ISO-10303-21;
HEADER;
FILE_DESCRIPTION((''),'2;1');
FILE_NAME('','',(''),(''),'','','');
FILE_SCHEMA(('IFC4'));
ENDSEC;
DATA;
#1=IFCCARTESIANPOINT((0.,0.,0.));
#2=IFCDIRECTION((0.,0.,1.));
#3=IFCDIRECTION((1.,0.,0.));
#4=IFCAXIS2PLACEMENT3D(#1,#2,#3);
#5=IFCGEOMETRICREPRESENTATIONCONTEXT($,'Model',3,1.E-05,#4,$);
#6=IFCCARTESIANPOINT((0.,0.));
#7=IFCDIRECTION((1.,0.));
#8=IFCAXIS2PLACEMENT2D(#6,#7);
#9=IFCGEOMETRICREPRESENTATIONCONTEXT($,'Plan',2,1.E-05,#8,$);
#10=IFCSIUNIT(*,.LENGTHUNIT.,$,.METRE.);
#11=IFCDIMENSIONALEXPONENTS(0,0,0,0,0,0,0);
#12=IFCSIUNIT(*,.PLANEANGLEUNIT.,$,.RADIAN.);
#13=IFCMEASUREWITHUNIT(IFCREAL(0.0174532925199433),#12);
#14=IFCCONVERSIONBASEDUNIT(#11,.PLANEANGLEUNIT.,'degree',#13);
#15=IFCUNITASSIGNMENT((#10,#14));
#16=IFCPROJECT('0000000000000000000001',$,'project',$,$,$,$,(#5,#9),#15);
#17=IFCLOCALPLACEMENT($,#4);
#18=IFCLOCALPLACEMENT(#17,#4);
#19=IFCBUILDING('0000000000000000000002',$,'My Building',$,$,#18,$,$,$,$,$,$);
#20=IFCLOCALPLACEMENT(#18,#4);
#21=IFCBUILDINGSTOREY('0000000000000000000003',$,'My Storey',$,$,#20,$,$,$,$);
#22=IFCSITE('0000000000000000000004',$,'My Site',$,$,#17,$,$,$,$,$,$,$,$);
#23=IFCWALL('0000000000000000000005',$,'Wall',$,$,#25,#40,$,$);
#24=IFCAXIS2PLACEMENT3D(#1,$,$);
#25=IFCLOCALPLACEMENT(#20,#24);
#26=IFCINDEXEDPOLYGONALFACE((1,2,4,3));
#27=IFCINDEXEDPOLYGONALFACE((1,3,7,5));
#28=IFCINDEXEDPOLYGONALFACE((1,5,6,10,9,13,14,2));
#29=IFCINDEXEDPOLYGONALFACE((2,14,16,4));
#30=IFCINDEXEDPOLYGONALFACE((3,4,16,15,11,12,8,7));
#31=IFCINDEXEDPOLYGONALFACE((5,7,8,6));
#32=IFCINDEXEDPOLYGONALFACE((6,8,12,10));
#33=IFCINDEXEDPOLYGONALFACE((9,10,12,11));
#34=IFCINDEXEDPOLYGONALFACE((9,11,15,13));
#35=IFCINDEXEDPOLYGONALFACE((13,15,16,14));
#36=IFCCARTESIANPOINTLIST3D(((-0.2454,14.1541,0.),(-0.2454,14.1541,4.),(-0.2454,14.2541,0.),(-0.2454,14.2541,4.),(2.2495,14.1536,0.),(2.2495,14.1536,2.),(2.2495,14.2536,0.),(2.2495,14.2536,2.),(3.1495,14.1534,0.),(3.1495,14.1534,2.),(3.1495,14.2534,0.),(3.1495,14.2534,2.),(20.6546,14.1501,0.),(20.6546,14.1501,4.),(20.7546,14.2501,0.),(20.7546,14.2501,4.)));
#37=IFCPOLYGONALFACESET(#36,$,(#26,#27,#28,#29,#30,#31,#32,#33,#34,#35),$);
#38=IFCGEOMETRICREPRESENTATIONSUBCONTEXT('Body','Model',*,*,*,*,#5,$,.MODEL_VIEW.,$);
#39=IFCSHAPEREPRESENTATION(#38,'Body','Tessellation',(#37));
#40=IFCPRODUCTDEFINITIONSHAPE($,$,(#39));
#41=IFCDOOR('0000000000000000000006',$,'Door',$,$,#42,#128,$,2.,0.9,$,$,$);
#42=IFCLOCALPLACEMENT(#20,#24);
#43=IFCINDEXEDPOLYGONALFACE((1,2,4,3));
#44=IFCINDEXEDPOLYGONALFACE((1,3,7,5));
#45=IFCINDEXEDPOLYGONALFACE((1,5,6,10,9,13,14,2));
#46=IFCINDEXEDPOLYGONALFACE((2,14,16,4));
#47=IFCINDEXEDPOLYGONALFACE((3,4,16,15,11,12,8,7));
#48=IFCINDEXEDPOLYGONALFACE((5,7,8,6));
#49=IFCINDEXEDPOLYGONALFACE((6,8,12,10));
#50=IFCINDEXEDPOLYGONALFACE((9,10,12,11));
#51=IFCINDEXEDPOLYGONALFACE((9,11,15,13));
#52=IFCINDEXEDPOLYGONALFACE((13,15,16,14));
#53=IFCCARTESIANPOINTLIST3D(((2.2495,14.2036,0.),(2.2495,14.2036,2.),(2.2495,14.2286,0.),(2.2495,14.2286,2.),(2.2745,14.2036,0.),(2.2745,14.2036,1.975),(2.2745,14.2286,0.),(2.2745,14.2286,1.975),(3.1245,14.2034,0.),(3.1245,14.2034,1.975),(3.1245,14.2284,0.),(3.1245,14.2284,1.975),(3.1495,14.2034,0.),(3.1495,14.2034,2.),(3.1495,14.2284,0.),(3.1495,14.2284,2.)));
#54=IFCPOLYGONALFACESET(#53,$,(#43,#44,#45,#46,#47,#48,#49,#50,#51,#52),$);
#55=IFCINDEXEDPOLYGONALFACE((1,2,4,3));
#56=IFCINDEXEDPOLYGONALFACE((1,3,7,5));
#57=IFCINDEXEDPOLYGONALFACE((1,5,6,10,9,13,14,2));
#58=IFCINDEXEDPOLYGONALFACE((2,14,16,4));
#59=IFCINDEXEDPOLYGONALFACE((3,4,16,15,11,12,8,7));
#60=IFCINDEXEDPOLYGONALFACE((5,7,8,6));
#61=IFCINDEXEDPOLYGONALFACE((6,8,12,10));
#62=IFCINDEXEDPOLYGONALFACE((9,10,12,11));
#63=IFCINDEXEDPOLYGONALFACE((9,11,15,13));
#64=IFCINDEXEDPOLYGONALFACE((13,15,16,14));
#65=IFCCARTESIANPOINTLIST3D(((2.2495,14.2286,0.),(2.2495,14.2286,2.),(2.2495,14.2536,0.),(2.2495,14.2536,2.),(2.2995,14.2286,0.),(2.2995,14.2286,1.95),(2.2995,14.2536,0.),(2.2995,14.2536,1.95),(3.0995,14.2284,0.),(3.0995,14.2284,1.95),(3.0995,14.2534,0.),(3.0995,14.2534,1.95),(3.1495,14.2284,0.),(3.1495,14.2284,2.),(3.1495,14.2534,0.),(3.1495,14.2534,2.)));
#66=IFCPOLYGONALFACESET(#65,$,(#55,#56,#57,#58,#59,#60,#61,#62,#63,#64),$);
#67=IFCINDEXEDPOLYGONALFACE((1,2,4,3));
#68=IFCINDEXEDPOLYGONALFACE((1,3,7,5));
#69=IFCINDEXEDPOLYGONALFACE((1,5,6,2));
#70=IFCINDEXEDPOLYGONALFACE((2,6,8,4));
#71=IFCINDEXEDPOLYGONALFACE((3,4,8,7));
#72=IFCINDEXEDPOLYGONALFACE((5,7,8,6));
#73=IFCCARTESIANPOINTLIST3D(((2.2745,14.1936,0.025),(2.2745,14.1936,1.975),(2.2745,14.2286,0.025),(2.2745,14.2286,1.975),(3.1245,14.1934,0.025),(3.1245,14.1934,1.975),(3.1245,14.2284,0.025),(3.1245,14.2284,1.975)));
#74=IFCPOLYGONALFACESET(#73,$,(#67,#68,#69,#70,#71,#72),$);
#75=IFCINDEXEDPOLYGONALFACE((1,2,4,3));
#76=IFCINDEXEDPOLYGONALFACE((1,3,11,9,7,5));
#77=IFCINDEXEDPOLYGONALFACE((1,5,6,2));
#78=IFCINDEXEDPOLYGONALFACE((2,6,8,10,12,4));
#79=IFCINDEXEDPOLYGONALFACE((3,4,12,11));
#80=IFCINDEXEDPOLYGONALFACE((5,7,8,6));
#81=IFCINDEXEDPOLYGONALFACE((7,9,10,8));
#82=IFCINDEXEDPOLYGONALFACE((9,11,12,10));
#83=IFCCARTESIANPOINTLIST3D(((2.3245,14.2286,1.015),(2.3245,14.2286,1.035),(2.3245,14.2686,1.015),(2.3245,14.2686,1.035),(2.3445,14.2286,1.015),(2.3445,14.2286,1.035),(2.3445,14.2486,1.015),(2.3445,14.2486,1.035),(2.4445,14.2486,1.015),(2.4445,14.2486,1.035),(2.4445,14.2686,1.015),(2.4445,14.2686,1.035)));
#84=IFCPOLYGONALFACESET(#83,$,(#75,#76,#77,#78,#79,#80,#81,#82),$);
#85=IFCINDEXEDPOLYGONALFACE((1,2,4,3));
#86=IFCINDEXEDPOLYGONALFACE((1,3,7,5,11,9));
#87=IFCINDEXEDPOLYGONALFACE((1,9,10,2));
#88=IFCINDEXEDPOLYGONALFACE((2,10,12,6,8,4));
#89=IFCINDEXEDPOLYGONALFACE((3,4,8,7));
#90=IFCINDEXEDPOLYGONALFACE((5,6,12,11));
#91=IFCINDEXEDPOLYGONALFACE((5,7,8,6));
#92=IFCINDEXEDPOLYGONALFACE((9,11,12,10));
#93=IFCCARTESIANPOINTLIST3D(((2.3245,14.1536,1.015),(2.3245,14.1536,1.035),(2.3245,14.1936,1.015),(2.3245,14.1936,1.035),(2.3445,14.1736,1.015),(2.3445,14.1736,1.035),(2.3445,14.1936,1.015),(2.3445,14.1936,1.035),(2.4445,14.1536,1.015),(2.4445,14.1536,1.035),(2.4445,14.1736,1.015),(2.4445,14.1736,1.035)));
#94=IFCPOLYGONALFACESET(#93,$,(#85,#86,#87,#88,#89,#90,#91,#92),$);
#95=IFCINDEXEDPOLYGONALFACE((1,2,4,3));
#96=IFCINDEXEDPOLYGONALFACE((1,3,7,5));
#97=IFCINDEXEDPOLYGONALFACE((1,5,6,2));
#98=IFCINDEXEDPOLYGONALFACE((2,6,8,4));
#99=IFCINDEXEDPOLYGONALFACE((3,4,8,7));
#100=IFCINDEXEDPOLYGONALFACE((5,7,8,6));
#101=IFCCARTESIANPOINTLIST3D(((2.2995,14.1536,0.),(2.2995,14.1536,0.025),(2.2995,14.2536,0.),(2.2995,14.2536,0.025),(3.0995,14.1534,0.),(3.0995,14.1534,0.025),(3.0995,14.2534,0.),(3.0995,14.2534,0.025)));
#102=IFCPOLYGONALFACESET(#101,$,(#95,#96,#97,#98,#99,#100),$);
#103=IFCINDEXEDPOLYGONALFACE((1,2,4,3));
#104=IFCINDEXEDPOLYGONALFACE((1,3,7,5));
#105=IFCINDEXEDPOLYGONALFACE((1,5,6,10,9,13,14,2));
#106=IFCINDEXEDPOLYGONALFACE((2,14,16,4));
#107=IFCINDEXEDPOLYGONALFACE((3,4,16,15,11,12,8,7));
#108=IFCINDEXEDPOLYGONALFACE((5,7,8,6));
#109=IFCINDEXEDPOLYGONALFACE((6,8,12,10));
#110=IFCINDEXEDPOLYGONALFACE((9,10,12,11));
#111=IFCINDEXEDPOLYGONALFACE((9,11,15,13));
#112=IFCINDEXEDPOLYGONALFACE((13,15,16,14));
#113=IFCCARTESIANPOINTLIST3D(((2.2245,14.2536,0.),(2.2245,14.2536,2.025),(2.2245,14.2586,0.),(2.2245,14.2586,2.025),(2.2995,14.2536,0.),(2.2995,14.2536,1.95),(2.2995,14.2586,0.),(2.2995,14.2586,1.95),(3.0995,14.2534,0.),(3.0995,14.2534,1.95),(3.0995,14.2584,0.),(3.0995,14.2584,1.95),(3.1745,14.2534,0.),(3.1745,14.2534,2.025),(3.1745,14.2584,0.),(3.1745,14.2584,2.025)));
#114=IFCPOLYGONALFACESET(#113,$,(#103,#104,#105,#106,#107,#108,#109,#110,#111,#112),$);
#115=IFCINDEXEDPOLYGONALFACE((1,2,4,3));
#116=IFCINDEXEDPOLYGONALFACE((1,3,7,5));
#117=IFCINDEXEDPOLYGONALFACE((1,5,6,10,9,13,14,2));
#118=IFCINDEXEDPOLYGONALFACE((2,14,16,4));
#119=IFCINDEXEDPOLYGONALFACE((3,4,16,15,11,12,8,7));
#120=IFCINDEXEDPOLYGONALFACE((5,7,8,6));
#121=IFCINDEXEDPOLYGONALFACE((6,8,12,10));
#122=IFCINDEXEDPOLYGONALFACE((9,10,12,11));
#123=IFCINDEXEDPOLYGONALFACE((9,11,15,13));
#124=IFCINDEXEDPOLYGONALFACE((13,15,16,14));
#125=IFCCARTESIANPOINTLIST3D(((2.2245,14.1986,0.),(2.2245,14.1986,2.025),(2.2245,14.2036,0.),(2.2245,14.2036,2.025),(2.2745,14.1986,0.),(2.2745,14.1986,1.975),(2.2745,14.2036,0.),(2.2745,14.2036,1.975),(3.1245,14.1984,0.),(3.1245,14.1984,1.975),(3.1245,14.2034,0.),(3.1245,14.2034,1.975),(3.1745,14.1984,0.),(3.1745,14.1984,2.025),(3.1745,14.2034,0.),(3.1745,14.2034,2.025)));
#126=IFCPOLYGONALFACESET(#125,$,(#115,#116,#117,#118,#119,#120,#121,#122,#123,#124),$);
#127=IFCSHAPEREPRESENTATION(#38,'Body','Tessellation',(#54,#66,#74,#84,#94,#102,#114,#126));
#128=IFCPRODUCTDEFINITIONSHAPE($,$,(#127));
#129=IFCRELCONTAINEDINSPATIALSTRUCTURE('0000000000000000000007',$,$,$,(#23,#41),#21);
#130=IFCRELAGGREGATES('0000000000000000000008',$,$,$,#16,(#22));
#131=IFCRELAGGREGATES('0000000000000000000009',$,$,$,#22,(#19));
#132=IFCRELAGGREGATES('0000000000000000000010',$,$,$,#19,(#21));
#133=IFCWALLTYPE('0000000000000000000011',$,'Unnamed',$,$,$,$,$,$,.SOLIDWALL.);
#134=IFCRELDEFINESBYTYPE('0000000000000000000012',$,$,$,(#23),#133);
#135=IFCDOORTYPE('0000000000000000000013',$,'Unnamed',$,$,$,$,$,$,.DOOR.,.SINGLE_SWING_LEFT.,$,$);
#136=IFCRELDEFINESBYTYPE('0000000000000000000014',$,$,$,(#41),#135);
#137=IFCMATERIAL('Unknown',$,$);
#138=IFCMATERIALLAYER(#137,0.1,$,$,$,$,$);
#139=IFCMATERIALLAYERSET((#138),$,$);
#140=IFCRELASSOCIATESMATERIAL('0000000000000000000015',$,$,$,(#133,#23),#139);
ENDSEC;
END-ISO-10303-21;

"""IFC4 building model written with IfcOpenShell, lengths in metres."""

from ifc_helpers import new_model, entity, si_unit, converted_unit, frame, origin_with_axes, origin_2d_with_axis, place, context, subcontext, project, spatial, line, indexed_curve, outline, extrude, shape, source, transform, mapped, material, layer, layer_set, layer_usage, type_object, type_shapes, element, fill, save


model = new_model("IFC4")

# Units and contexts
model_context = context("Model", 3, precision=1e-05, world=origin_with_axes())
plan_context = context("Plan", 2, precision=1e-05, world=origin_2d_with_axis())
body_context_1 = subcontext(model_context, "Body", "Model", "MODEL_VIEW")
body_context_2 = subcontext(plan_context, "Body", "Plan", "PLAN_VIEW")
ifc_project = project(units=[si_unit("LENGTHUNIT", "METRE"), converted_unit("PLANEANGLEUNIT", "degree", entity("IfcReal", 0.0174532925199433), si_unit("PLANEANGLEUNIT", "RADIAN"), dimensions=[0, 0, 0, 0, 0, 0, 0])], contexts=[model_context, plan_context])

# Site, building, storey
site_placement = place(None, origin_with_axes())
site = spatial("IfcSite", under=ifc_project, at=site_placement, Name="My Site")
building_placement = place(site_placement, origin_with_axes())
building = spatial("IfcBuilding", under=site, at=building_placement, Name="My Building")
storey_placement = place(building_placement, origin_with_axes())
storey = spatial("IfcBuildingStorey", under=building, at=storey_placement, Name="My Storey")

# Shared definitions
ifc_material = material(Name="Unknown")

# Wall, opening, door
ifc_layer_1 = layer(ifc_material, 0.1)
ifc_layer_set_1 = layer_set([ifc_layer_1])
ifc_layer_usage_1 = layer_usage(ifc_layer_set_1, "AXIS2", "POSITIVE", 0.0)
wall_type = type_object("IfcWallType", Name="Unnamed", PredefinedType="SOLIDWALL", material=ifc_layer_set_1)
wall_1_placement = place(storey_placement, frame((20.7546, 14.2501, 0.0), z_axis=(0.0, 0.0, 1.0), x_axis=(-1.0, 0.000191, 0.0)))
wall_1 = element("IfcWall", 1, at=wall_1_placement, inside=storey, type_object=wall_type, material=ifc_layer_usage_1, Name="Wall", context=body_context_1, shape_type="SweptSolid", body=[
    extrude(outline(indexed_curve([(0.0, 0.0), (0.1, 0.1), (21.0, 0.1), (21.0, 0.0)], segments=[line(1, 2, 3, 4, 1)])), origin_with_axes(), (0.0, 0.0, 1.0), 4.0),
])
shared_shape_1 = source(origin_with_axes(), body_context_1, "Body", "SweptSolid", [
    extrude(outline(indexed_curve([(0.0, 0.0), (0.9, 0.0), (0.9, 2.0), (0.0, 2.0)], segments=[line(1, 2, 3, 4, 1)])), frame((0.0, -0.6, 0.0), z_axis=(0.0, -1.0, 0.0), x_axis=(1.0, 0.0, 0.0)), (0.0, 0.0, -1.0), 1.2),
])
opening_1_placement = place(wall_1_placement, frame((17.6051, 0.0, 0.0), z_axis=(0.0, 0.0, 1.0), x_axis=(1.0, 0.0, 0.0)))
opening_1 = element("IfcOpeningElement", 2, at=opening_1_placement, cuts=wall_1, PredefinedType="OPENING", context=body_context_1, shape_type="MappedRepresentation", body=[
    mapped(shared_shape_1, transform((0.0, 0.0, 0.0), x_axis=(1.0, 0.0, 0.0), y_axis=(0.0, 1.0, 0.0), z_axis=(0.0, 0.0, 1.0), scale=1.0)),
])
door_type = type_object("IfcDoorType", Name="Unnamed", OperationType="SINGLE_SWING_LEFT", PredefinedType="DOOR")
shared_shape_2 = source(origin_with_axes(), body_context_1, "Body", "SweptSolid", [
    extrude(outline(indexed_curve([(0.0, 0.0), (0.0, 2.0), (0.9, 2.0), (0.9, 0.0), (0.875, 0.0), (0.875, 1.975), (0.025, 1.975), (0.025, 0.0)], segments=[line(1, 2, 3, 4, 5, 6, 7, 8, 1)])), frame((0.0, 0.025, 0.0), z_axis=(0.0, -1.0, 0.0), x_axis=(1.0, 0.0, 0.0)), (0.0, 0.0, -1.0), 0.025),
    extrude(outline(indexed_curve([(0.0, 0.0), (0.0, 2.0), (0.9, 2.0), (0.9, 0.0), (0.85, 0.0), (0.85, 1.95), (0.05, 1.95), (0.05, 0.0)], segments=[line(1, 2, 3, 4, 5, 6, 7, 8, 1)])), frame((0.0, 0.0, 0.0), z_axis=(0.0, -1.0, 0.0), x_axis=(1.0, 0.0, 0.0)), (0.0, 0.0, -1.0), 0.025),
    extrude(outline(indexed_curve([(0.0, 0.0), (0.85, 0.0), (0.85, 0.035), (0.0, 0.035)], segments=[line(1, 2, 3, 4, 1)])), frame((0.025, 0.025, 0.025), z_axis=(0.0, 0.0, 1.0), x_axis=(1.0, 0.0, 0.0)), (0.0, 0.0, 1.0), 1.95),
    extrude(outline(indexed_curve([(0.0, 0.0), (0.0, -0.04), (-0.12, -0.04), (-0.12, -0.02), (-0.02, -0.02), (-0.02, 0.0)], segments=[line(1, 2, 3, 4, 5, 6, 1)])), frame((0.825, 0.025, 1.015), z_axis=(0.0, 0.0, 1.0), x_axis=(1.0, 0.0, 0.0)), (0.0, 0.0, 1.0), 0.02),
    extrude(outline(indexed_curve([(0.0, 0.0), (0.0, 0.04), (-0.12, 0.04), (-0.12, 0.02), (-0.02, 0.02), (-0.02, 0.0)], segments=[line(1, 2, 3, 4, 5, 6, 1)])), frame((0.825, 0.06, 1.015), z_axis=(0.0, 0.0, 1.0), x_axis=(1.0, 0.0, 0.0)), (0.0, 0.0, 1.0), 0.02),
    extrude(outline(indexed_curve([(0.0, 0.0), (0.8, 0.0), (0.8, 0.1), (0.0, 0.1)], segments=[line(1, 2, 3, 4, 1)])), frame((0.05, 0.0, 0.0), z_axis=(0.0, 0.0, 1.0), x_axis=(1.0, 0.0, 0.0)), (0.0, 0.0, 1.0), 0.025),
    extrude(outline(indexed_curve([(0.0, 0.0), (0.0, 2.025), (0.95, 2.025), (0.95, 0.0), (0.875, 0.0), (0.875, 1.95), (0.075, 1.95), (0.075, 0.0)], segments=[line(1, 2, 3, 4, 5, 6, 7, 8, 1)])), frame((-0.025, -0.005, 0.0), z_axis=(0.0, -1.0, 0.0), x_axis=(1.0, 0.0, 0.0)), (0.0, 0.0, -1.0), 0.005),
    extrude(outline(indexed_curve([(0.0, 0.0), (0.0, 2.025), (0.95, 2.025), (0.95, 0.0), (0.9, 0.0), (0.9, 1.975), (0.05, 1.975), (0.05, 0.0)], segments=[line(1, 2, 3, 4, 5, 6, 7, 8, 1)])), frame((-0.025, 0.05, 0.0), z_axis=(0.0, -1.0, 0.0), x_axis=(1.0, 0.0, 0.0)), (0.0, 0.0, -1.0), 0.005),
])
shared_shape_3 = source(origin_with_axes(), body_context_2, "Body", "Curve2D", [
    entity("IfcIndexedPolyCurve", entity("IfcCartesianPointList2D", [[0.0, 0.0], [0.0, 0.05], [0.025, 0.05], [0.025, 0.025], [0.05, 0.025], [0.05, 0.0]]), [entity("IfcLineIndex", [1, 2, 3, 4, 5, 6, 1])]),
    entity("IfcIndexedPolyCurve", entity("IfcCartesianPointList2D", [[0.9, 0.0], [0.9, 0.05], [0.875, 0.05], [0.875, 0.025], [0.85, 0.025], [0.85, 0.0]]), [entity("IfcLineIndex", [1, 2, 3, 4, 5, 6, 1])]),
    entity("IfcTrimmedCurve", entity("IfcEllipse", entity("IfcAxis2Placement2D", entity("IfcCartesianPoint", [0.06, 0.05]), entity("IfcDirection", [1.0, 0.0])), 0.815, 0.85), [entity("IfcCartesianPoint", [0.875, 0.05])], [entity("IfcCartesianPoint", [0.06, 0.9])], True, "CARTESIAN"),
    entity("IfcIndexedPolyCurve", entity("IfcCartesianPointList2D", [[0.025, 0.05], [0.06, 0.05], [0.06, 0.9], [0.025, 0.9]]), [entity("IfcLineIndex", [1, 2, 3, 4, 1])]),
])
type_shapes(door_type, [shared_shape_2, shared_shape_3])
door_1_placement = place(opening_1_placement, origin_with_axes())
door_1 = element("IfcDoor", 3, at=door_1_placement, inside=storey, type_object=door_type, Name="Door", OverallHeight=2.0, OverallWidth=0.9, shapes=[
    shape(body_context_1, "Body", "MappedRepresentation", [mapped(shared_shape_2, transform((0.0, 0.0, 0.0), x_axis=(1.0, 0.0, 0.0), y_axis=(0.0, 1.0, 0.0), z_axis=(0.0, 0.0, 1.0), scale=1.0))]),
    shape(body_context_2, "Body", "MappedRepresentation", [mapped(shared_shape_3, transform((0.0, 0.0, 0.0), x_axis=(1.0, 0.0, 0.0), y_axis=(0.0, 1.0, 0.0), z_axis=(0.0, 0.0, 1.0), scale=1.0))]),
])
fill(opening_1, door_1)

save(model, "model.ifc")
